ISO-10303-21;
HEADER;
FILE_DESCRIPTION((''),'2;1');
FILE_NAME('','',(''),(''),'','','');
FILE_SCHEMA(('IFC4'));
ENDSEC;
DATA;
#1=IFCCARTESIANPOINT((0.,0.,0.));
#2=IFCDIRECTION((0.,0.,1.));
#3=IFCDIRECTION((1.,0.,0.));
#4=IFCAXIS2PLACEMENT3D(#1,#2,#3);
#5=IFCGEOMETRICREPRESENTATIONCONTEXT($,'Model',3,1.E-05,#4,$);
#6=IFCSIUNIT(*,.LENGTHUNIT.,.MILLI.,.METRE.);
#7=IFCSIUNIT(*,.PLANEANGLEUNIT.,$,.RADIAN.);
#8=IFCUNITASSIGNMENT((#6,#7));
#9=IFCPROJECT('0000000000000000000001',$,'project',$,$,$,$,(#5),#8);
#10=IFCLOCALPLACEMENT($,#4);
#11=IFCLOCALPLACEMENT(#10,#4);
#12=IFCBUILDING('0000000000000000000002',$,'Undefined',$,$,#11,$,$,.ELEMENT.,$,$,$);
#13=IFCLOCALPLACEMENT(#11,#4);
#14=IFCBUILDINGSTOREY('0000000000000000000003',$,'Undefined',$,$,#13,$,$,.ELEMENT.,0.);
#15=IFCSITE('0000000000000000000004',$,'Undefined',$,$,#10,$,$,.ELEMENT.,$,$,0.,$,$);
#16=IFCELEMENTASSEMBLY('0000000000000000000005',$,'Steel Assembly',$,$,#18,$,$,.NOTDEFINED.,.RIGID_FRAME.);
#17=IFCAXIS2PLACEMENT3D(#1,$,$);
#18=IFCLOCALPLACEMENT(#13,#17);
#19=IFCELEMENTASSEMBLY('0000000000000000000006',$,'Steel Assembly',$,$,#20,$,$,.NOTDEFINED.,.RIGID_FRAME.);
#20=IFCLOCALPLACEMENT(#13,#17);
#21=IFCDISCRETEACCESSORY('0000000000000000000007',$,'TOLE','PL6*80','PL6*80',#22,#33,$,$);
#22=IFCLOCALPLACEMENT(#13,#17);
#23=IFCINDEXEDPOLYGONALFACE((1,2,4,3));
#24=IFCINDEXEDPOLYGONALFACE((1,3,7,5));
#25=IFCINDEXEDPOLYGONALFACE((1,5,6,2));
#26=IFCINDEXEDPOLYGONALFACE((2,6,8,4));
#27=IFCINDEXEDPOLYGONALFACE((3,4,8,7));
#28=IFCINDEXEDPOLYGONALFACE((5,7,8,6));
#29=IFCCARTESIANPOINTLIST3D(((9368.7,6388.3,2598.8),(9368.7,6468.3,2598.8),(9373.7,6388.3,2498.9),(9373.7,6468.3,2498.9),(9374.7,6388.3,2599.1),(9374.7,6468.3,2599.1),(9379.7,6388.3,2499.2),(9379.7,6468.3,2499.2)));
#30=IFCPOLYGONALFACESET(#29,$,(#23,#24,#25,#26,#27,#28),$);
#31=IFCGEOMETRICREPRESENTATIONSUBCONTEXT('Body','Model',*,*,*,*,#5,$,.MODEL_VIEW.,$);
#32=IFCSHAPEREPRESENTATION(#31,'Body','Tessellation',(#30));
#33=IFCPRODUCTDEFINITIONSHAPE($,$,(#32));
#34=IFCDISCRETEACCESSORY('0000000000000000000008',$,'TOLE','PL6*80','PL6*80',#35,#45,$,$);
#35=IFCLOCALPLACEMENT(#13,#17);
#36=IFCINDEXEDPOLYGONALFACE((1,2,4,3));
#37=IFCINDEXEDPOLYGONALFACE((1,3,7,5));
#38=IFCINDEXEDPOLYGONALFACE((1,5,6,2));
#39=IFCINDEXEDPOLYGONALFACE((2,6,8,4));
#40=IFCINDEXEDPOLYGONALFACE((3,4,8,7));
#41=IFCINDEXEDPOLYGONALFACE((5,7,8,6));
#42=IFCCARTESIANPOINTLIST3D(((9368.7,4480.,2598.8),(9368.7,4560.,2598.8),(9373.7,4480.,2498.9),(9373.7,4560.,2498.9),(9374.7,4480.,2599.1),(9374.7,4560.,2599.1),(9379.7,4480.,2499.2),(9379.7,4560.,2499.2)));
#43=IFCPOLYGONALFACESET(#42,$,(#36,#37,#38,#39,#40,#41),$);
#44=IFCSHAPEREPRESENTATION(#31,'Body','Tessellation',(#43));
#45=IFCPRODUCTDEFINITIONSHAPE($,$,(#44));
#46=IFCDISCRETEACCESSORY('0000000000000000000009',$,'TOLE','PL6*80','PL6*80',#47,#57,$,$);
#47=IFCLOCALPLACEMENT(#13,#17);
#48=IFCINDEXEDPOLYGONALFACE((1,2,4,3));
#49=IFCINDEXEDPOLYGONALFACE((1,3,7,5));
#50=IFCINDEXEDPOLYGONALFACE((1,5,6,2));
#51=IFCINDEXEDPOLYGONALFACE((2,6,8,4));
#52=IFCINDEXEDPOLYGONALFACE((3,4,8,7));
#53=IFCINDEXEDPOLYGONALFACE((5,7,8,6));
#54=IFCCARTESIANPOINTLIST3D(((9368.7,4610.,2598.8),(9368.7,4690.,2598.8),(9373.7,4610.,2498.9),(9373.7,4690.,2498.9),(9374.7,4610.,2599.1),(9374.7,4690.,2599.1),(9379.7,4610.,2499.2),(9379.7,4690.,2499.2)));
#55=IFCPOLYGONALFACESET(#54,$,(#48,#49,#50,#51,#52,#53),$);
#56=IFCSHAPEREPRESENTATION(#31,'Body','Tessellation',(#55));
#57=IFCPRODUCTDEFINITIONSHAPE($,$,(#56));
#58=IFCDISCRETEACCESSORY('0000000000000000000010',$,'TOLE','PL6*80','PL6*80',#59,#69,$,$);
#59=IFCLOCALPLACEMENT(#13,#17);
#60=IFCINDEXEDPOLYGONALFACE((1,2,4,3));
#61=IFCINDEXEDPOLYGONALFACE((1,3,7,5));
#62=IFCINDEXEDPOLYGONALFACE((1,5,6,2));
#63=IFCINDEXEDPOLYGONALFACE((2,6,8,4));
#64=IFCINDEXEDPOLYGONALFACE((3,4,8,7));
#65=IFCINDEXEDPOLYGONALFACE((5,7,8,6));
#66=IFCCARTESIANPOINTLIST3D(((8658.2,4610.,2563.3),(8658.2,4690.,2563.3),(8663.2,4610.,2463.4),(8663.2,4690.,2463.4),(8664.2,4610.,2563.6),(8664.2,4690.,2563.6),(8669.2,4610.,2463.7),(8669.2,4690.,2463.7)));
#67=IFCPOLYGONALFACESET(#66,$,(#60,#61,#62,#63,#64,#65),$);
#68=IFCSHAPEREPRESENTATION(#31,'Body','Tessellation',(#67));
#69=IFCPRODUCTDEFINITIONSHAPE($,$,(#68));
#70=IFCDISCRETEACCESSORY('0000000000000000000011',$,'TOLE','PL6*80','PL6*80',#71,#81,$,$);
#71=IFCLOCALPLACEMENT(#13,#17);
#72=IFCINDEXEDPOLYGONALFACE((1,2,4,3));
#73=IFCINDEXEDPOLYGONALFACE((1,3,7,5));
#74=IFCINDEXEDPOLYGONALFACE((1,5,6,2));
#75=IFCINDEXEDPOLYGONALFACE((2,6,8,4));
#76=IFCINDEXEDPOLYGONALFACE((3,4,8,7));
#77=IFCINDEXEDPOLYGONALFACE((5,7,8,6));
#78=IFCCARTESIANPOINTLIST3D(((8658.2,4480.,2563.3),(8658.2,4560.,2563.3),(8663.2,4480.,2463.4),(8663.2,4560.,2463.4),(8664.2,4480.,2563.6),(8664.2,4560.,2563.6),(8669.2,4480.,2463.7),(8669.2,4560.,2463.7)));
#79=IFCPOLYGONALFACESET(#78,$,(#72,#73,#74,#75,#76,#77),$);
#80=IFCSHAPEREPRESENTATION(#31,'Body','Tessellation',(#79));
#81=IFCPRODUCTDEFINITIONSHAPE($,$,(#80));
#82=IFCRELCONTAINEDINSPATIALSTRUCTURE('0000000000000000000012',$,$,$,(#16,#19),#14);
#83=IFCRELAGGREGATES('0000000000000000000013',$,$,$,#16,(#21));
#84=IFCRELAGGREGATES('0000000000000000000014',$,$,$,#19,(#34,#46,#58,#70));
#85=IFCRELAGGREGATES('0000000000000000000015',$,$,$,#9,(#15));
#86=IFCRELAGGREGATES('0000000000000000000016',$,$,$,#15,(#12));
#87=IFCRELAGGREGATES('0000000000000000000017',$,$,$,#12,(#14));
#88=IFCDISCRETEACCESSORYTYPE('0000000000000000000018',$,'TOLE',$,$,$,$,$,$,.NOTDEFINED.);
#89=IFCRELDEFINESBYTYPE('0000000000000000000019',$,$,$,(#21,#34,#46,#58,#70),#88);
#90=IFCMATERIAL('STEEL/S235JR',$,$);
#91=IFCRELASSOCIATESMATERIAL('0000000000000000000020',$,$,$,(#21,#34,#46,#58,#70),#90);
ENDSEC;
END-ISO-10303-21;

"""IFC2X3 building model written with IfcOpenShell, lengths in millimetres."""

from ifc_helpers import new_model, si_unit, frame, origin_with_axes, origin_2d_with_axis, place, context, subcontext, project, spatial, rectangle, extrude, material, type_object, element, aggregate, save


model = new_model("IFC2X3")

# Units and contexts
model_context = context("Model", 3, precision=1e-05, world=origin_with_axes())
body_context = subcontext(model_context, "Body", "Model", "MODEL_VIEW")
ifc_project = project(units=[si_unit("LENGTHUNIT", "METRE", prefix="MILLI"), si_unit("PLANEANGLEUNIT", "RADIAN")], contexts=[model_context])

# Site, building, storey
site_placement = place(None, origin_with_axes())
site = spatial("IfcSite", under=ifc_project, at=site_placement, Name="Undefined", CompositionType="ELEMENT", RefElevation=0.0)
building_placement = place(site_placement, origin_with_axes())
building = spatial("IfcBuilding", under=site, at=building_placement, Name="Undefined", CompositionType="ELEMENT")
storey_placement = place(building_placement, origin_with_axes())
storey = spatial("IfcBuildingStorey", under=building, at=storey_placement, Name="Undefined", CompositionType="ELEMENT", Elevation=0.0)

# Element assemblies
assembly_1_placement = place(storey_placement, origin_with_axes())
assembly_1 = element("IfcElementAssembly", 1, at=assembly_1_placement, inside=storey, Name="Steel Assembly", AssemblyPlace="NOTDEFINED", PredefinedType="RIGID_FRAME")
ifc_material_1 = material(Name="STEEL/S235JR")
assembly_2_placement = place(storey_placement, origin_with_axes())
assembly_2 = element("IfcElementAssembly", 2, at=assembly_2_placement, inside=storey, Name="Steel Assembly", AssemblyPlace="NOTDEFINED", PredefinedType="RIGID_FRAME")

# Discrete accessories
discrete_accessory_type_1 = type_object("IfcDiscreteAccessoryType", Name="TOLE")
discrete_accessory_1_placement = place(assembly_1_placement, frame((9371.7, 6428.3, 2598.9), z_axis=(0.0, 1.0, 0.0), x_axis=(0.049938, 0.0, -0.998752)))
discrete_accessory_1 = element("IfcDiscreteAccessory", 3, at=discrete_accessory_1_placement, type_object=discrete_accessory_type_1, material=ifc_material_1, Name="TOLE", Description="PL6*80", ObjectType="PL6*80", context=body_context, shape_type="SweptSolid", body=[
    extrude(rectangle(XDim=6.0, YDim=80.0, at=origin_2d_with_axis()), frame((100.0, 0.0, 0.0), z_axis=(-1.0, 0.0, 0.0), x_axis=(0.0, -1.0, 0.0)), (0.0, 0.0, 1.0), 100.0),
])
aggregate(assembly_1, [discrete_accessory_1])
discrete_accessory_2_placement = place(assembly_2_placement, frame((9371.7, 4520.0, 2598.9), z_axis=(0.0, 1.0, 0.0), x_axis=(0.049938, 0.0, -0.998752)))
discrete_accessory_2 = element("IfcDiscreteAccessory", 4, at=discrete_accessory_2_placement, type_object=discrete_accessory_type_1, material=ifc_material_1, Name="TOLE", Description="PL6*80", ObjectType="PL6*80", context=body_context, shape_type="SweptSolid", body=[
    extrude(rectangle(XDim=6.0, YDim=80.0, at=origin_2d_with_axis()), frame((100.0, 0.0, 0.0), z_axis=(-1.0, 0.0, 0.0), x_axis=(0.0, -1.0, 0.0)), (0.0, 0.0, 1.0), 100.0),
])
discrete_accessory_3_placement = place(assembly_2_placement, frame((9371.7, 4650.0, 2598.9), z_axis=(0.0, -1.0, 0.0), x_axis=(0.049938, 0.0, -0.998752)))
discrete_accessory_3 = element("IfcDiscreteAccessory", 5, at=discrete_accessory_3_placement, type_object=discrete_accessory_type_1, material=ifc_material_1, Name="TOLE", Description="PL6*80", ObjectType="PL6*80", context=body_context, shape_type="SweptSolid", body=[
    extrude(rectangle(XDim=6.0, YDim=80.0, at=origin_2d_with_axis()), frame((100.0, 0.0, 0.0), z_axis=(-1.0, 0.0, 0.0), x_axis=(0.0, -1.0, 0.0)), (0.0, 0.0, 1.0), 100.0),
])
discrete_accessory_4_placement = place(assembly_2_placement, frame((8661.2, 4650.0, 2563.4), z_axis=(0.0, -1.0, 0.0), x_axis=(0.049938, 0.0, -0.998752)))
discrete_accessory_4 = element("IfcDiscreteAccessory", 6, at=discrete_accessory_4_placement, type_object=discrete_accessory_type_1, material=ifc_material_1, Name="TOLE", Description="PL6*80", ObjectType="PL6*80", context=body_context, shape_type="SweptSolid", body=[
    extrude(rectangle(XDim=6.0, YDim=80.0, at=origin_2d_with_axis()), frame((100.0, 0.0, 0.0), z_axis=(-1.0, 0.0, 0.0), x_axis=(0.0, -1.0, 0.0)), (0.0, 0.0, 1.0), 100.0),
])
discrete_accessory_5_placement = place(assembly_2_placement, frame((8661.2, 4520.0, 2563.4), z_axis=(0.0, 1.0, 0.0), x_axis=(0.049938, 0.0, -0.998752)))
discrete_accessory_5 = element("IfcDiscreteAccessory", 7, at=discrete_accessory_5_placement, type_object=discrete_accessory_type_1, material=ifc_material_1, Name="TOLE", Description="PL6*80", ObjectType="PL6*80", context=body_context, shape_type="SweptSolid", body=[
    extrude(rectangle(XDim=6.0, YDim=80.0, at=origin_2d_with_axis()), frame((100.0, 0.0, 0.0), z_axis=(-1.0, 0.0, 0.0), x_axis=(0.0, -1.0, 0.0)), (0.0, 0.0, 1.0), 100.0),
])

aggregate(assembly_2, [discrete_accessory_2, discrete_accessory_3, discrete_accessory_4, discrete_accessory_5])

save(model, "model.ifc")
